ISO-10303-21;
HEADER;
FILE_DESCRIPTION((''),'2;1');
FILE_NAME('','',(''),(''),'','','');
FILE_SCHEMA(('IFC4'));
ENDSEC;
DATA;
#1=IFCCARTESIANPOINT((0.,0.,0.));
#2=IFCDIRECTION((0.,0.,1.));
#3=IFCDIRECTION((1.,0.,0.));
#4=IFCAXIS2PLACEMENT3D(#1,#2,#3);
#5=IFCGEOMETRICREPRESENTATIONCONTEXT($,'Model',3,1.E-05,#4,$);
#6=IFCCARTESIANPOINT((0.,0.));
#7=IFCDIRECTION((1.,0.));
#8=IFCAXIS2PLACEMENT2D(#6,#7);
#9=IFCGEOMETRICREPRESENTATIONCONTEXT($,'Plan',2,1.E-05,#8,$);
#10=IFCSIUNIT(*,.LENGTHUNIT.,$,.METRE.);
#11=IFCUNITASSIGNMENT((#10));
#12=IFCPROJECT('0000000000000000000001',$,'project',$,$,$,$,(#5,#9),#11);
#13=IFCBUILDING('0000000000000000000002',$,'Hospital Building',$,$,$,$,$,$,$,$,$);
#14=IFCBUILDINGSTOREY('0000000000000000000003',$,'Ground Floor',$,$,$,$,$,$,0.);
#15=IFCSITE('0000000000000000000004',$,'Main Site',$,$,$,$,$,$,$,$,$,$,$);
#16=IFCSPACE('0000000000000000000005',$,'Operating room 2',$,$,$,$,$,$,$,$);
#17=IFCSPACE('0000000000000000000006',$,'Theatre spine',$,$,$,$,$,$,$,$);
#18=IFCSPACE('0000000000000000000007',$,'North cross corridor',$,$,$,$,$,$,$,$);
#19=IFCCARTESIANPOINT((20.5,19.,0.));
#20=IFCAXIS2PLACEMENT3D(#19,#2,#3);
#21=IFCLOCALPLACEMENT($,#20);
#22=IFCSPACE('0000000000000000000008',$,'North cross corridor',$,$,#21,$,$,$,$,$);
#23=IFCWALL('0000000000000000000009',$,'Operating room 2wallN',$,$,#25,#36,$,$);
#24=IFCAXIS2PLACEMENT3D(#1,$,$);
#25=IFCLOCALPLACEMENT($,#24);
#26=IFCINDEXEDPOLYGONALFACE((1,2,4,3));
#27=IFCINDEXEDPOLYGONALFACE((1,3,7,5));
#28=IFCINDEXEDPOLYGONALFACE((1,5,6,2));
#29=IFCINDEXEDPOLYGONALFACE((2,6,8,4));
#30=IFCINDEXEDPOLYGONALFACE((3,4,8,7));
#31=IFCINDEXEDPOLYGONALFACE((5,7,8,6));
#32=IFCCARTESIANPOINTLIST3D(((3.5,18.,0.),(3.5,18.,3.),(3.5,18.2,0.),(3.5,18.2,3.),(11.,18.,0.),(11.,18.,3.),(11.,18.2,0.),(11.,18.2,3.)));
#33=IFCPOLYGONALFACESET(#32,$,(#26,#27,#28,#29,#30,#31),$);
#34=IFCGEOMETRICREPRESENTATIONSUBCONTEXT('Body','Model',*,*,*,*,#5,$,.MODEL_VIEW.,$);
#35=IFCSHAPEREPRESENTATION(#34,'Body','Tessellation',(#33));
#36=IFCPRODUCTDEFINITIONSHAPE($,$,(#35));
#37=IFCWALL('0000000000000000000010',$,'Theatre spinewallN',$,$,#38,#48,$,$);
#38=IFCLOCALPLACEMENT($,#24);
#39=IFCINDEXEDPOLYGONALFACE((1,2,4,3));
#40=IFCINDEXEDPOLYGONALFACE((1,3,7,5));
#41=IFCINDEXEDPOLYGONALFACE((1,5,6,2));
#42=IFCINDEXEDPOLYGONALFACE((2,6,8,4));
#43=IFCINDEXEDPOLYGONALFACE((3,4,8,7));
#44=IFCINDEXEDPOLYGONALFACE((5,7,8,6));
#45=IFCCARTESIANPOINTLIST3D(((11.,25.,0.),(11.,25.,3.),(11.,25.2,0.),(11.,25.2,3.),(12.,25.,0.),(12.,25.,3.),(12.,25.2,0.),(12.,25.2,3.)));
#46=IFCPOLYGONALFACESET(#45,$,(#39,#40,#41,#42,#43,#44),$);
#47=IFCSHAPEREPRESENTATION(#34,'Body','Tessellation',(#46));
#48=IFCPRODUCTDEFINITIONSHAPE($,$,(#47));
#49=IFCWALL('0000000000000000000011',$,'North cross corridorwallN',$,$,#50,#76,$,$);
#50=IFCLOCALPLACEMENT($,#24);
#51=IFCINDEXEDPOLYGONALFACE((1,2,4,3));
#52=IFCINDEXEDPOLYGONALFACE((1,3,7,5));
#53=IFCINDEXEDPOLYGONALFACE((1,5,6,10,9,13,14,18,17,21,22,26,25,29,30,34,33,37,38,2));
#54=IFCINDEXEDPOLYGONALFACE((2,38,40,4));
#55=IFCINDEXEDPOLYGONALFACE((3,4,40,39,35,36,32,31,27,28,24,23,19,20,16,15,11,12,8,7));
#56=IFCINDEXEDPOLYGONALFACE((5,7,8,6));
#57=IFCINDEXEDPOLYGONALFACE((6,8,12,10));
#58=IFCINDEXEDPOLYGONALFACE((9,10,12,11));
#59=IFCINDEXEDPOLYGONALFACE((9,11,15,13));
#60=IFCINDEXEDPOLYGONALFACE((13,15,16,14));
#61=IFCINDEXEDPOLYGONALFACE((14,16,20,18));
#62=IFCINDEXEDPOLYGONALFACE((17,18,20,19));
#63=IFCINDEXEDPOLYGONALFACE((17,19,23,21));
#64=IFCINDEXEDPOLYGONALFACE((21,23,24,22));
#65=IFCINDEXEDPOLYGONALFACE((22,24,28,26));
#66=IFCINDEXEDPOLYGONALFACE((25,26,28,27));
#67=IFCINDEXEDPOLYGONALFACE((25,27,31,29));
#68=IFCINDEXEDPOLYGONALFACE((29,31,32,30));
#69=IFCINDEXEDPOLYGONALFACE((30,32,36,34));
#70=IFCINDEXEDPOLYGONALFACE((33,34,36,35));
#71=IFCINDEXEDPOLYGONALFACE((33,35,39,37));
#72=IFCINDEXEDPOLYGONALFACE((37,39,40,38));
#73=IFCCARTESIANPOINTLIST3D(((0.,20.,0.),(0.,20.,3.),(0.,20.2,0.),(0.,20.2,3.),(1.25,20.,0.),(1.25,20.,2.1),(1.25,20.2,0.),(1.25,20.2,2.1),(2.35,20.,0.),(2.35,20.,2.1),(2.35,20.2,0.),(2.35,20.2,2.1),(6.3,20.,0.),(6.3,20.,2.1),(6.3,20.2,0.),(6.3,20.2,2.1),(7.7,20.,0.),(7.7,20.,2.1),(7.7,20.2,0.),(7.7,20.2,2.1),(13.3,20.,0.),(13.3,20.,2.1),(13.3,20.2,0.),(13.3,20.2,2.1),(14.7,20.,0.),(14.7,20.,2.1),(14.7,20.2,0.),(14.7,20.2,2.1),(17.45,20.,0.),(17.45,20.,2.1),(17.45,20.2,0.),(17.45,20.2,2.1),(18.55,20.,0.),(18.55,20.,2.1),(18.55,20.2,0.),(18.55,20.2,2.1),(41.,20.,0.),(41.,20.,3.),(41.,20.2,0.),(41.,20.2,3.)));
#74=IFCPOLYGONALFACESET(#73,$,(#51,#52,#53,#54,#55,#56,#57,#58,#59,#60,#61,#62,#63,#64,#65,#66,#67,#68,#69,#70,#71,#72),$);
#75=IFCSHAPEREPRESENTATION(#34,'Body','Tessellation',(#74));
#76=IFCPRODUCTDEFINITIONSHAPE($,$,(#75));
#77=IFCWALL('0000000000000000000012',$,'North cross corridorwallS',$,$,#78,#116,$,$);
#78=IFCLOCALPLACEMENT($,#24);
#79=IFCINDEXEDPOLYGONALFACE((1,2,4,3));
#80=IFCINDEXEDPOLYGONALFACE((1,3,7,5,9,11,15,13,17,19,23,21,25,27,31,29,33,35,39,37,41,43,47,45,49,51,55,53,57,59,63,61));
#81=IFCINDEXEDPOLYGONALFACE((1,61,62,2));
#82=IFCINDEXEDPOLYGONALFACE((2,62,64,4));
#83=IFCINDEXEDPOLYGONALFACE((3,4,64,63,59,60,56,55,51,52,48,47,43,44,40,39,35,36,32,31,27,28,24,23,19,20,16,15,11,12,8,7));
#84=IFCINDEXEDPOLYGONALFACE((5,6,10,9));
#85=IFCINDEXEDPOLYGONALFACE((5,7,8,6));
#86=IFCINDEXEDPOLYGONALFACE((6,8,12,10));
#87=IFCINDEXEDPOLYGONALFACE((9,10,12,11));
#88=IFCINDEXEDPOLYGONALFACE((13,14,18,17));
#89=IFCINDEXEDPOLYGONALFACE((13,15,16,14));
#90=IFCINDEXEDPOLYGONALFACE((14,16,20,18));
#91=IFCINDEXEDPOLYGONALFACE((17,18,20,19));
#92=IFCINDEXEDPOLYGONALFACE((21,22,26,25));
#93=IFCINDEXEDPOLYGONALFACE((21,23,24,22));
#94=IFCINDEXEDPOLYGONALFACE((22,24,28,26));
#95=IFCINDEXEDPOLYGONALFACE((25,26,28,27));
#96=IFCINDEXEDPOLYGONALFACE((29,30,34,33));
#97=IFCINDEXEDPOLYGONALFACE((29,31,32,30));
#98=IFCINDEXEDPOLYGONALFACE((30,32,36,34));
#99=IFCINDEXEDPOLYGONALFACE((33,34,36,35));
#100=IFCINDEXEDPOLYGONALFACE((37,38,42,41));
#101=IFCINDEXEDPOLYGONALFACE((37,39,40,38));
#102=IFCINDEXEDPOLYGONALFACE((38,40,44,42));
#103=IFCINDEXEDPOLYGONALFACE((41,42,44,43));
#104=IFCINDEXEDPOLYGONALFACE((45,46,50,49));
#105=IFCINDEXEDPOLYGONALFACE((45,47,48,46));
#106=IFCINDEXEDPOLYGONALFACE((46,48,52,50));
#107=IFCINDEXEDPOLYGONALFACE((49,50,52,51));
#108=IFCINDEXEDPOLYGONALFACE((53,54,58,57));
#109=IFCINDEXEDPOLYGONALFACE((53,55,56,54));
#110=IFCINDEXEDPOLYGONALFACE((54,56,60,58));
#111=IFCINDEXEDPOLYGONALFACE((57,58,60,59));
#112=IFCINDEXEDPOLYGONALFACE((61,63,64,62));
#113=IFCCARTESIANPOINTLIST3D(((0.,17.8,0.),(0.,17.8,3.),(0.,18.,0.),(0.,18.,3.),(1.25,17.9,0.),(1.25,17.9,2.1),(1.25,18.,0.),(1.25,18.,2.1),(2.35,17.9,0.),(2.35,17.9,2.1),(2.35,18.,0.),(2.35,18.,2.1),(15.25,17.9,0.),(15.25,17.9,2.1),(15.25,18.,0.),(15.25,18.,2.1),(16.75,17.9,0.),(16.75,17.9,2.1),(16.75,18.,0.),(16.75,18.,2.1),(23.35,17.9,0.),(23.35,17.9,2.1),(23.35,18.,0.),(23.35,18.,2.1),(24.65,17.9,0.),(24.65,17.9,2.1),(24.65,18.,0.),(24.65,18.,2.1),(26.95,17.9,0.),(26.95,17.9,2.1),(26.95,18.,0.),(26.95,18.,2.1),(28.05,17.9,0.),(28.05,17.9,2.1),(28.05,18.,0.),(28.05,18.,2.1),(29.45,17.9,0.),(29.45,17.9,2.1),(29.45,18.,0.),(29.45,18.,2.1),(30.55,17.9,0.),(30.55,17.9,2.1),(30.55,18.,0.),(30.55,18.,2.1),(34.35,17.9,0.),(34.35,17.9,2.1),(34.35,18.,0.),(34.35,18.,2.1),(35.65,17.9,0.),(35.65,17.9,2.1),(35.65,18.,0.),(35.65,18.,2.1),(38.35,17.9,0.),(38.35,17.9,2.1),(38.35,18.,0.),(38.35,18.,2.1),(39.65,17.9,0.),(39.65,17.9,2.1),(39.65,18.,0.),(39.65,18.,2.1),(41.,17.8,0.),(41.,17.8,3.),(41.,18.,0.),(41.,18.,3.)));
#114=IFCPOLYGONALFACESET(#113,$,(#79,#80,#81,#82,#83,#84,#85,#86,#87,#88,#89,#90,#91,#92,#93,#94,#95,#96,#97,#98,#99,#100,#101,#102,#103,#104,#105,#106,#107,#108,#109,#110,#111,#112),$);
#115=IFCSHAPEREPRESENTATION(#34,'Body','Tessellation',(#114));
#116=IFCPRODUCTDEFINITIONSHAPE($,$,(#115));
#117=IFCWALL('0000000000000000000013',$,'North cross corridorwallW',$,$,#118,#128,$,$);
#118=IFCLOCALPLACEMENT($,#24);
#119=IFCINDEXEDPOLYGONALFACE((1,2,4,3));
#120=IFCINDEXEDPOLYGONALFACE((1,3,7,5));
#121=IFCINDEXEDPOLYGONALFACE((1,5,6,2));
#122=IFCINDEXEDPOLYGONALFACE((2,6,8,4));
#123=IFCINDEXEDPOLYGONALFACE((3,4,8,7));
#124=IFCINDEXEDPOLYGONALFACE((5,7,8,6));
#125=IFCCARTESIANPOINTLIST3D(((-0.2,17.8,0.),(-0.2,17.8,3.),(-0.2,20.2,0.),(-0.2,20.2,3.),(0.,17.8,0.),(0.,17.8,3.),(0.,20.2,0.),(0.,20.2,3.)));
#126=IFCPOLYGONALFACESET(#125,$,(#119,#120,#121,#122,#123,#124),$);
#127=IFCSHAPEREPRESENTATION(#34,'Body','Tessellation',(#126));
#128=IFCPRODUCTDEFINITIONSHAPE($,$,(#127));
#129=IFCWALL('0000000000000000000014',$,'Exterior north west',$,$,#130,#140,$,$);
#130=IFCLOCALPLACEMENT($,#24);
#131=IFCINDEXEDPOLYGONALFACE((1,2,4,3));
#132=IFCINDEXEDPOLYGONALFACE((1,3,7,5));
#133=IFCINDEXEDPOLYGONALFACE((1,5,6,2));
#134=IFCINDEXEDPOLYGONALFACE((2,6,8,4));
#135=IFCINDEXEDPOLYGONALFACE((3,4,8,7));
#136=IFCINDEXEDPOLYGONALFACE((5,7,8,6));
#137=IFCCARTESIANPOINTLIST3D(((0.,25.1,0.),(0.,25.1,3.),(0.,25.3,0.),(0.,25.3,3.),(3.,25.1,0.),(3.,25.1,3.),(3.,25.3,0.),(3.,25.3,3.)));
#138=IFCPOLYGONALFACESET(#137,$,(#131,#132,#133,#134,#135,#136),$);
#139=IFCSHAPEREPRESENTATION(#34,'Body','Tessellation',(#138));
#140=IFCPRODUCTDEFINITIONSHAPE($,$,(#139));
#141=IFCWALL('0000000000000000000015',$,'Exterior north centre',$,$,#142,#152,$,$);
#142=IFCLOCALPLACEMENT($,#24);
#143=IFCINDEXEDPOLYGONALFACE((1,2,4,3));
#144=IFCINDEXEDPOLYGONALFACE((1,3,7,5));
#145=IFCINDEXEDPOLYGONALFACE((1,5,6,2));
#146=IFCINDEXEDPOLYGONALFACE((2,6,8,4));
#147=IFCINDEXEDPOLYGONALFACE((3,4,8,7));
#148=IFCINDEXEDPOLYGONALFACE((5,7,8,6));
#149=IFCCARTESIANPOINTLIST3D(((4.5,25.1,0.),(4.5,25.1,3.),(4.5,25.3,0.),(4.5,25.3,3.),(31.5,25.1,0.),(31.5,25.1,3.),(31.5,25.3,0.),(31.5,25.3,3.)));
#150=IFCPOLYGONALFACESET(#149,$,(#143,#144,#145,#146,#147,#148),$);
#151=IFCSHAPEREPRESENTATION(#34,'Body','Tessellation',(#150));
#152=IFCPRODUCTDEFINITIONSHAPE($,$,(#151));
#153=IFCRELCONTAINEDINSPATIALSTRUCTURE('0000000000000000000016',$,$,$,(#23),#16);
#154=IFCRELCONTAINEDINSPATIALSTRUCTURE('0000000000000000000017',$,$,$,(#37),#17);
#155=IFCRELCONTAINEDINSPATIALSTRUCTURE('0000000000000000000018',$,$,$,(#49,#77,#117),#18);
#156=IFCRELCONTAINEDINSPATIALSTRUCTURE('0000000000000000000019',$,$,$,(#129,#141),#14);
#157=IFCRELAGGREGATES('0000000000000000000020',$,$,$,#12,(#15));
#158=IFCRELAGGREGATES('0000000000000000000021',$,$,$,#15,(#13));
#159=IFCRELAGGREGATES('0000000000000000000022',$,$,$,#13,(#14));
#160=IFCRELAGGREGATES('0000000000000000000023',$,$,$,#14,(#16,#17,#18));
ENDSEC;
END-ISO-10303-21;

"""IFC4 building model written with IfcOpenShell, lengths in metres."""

from ifc_helpers import new_model, si_unit, frame, origin_with_axes, origin_2d_with_axis, place, context, subcontext, project, spatial, indexed_curve, outline, extrude, element, save


model = new_model("IFC4")

# Units and contexts
model_context = context("Model", 3, precision=1e-05, world=origin_with_axes())
plan_context = context("Plan", 2, precision=1e-05, world=origin_2d_with_axis())
body_context = subcontext(model_context, "Body", "Model", "MODEL_VIEW")
ifc_project = project(units=[si_unit("LENGTHUNIT", "METRE")], contexts=[model_context, plan_context])

# Site, building, storey
site = spatial("IfcSite", under=ifc_project, Name="Main Site")
building = spatial("IfcBuilding", under=site, Name="Hospital Building")
storey = spatial("IfcBuildingStorey", under=building, Name="Ground Floor", Elevation=0.0)

# Shared definitions
space_1 = spatial("IfcSpace", under=storey, Name="Operating room 2")

# Shared definitions
space_2 = spatial("IfcSpace", under=storey, Name="Theatre spine")

# Walls
wall_1_placement = place(None, frame((3.5, 18.0, 0.0), z_axis=(0.0, 0.0, 1.0), x_axis=(1.0, 0.0, 0.0)))
element("IfcWall", 1, at=wall_1_placement, inside=space_1, Name="Operating room 2wallN", context=body_context, shape_type="SweptSolid", body=[
    extrude(outline(indexed_curve([(0.0, 0.0), (0.0, 0.2), (7.5, 0.2), (7.5, 0.0), (0.0, 0.0)], self_intersect=False)), origin_with_axes(), (0.0, 0.0, 1.0), 3.0),
])
wall_2_placement = place(None, frame((11.0, 25.0, 0.0), z_axis=(0.0, 0.0, 1.0), x_axis=(1.0, 0.0, 0.0)))
element("IfcWall", 2, at=wall_2_placement, inside=space_2, Name="Theatre spinewallN", context=body_context, shape_type="SweptSolid", body=[
    extrude(outline(indexed_curve([(0.0, 0.0), (0.0, 0.2), (1.0, 0.2), (1.0, 0.0), (0.0, 0.0)], self_intersect=False)), origin_with_axes(), (0.0, 0.0, 1.0), 3.0),
])

# Shared definitions
space_3 = spatial("IfcSpace", under=storey, Name="North cross corridor")

# Wall
wall_3_placement = place(None, frame((0.0, 20.0, 0.0), z_axis=(0.0, 0.0, 1.0), x_axis=(1.0, 0.0, 0.0)))
wall_3 = element("IfcWall", 3, at=wall_3_placement, inside=space_3, Name="North cross corridorwallN", context=body_context, shape_type="SweptSolid", body=[
    extrude(outline(indexed_curve([(0.0, 0.0), (0.0, 0.2), (41.0, 0.2), (41.0, 0.0), (0.0, 0.0)], self_intersect=False)), origin_with_axes(), (0.0, 0.0, 1.0), 3.0),
])

# Shared definitions
space_4_placement = place(None, frame((20.5, 19.0, 0.0), z_axis=(0.0, 0.0, 1.0), x_axis=(1.0, 0.0, 0.0)))
space_4 = spatial("IfcSpace", at=space_4_placement, Name="North cross corridor")

# Openings
opening_1_placement = place(wall_3_placement, frame((1.25, -0.1, 0.0), z_axis=(0.0, 0.0, 1.0), x_axis=(1.0, 0.0, 0.0)))
element("IfcOpeningElement", 4, at=opening_1_placement, inside=space_4, cuts=wall_3, context=body_context, shape_type="SweptSolid", body=[
    extrude(outline(indexed_curve([(0.0, 0.0), (0.0, 0.4), (1.1, 0.4), (1.1, 0.0), (0.0, 0.0)], self_intersect=False)), origin_with_axes(), (0.0, 0.0, 1.0), 2.1),
])
opening_2_placement = place(wall_3_placement, frame((6.3, -0.1, 0.0), z_axis=(0.0, 0.0, 1.0), x_axis=(1.0, 0.0, 0.0)))
element("IfcOpeningElement", 5, at=opening_2_placement, inside=space_4, cuts=wall_3, context=body_context, shape_type="SweptSolid", body=[
    extrude(outline(indexed_curve([(0.0, 0.0), (0.0, 0.4), (1.4, 0.4), (1.4, 0.0), (0.0, 0.0)], self_intersect=False)), origin_with_axes(), (0.0, 0.0, 1.0), 2.1),
])
opening_3_placement = place(wall_3_placement, frame((13.3, -0.1, 0.0), z_axis=(0.0, 0.0, 1.0), x_axis=(1.0, 0.0, 0.0)))
element("IfcOpeningElement", 6, at=opening_3_placement, inside=space_4, cuts=wall_3, context=body_context, shape_type="SweptSolid", body=[
    extrude(outline(indexed_curve([(0.0, 0.0), (0.0, 0.4), (1.4, 0.4), (1.4, 0.0), (0.0, 0.0)], self_intersect=False)), origin_with_axes(), (0.0, 0.0, 1.0), 2.1),
])
opening_4_placement = place(wall_3_placement, frame((17.45, -0.1, 0.0), z_axis=(0.0, 0.0, 1.0), x_axis=(1.0, 0.0, 0.0)))
element("IfcOpeningElement", 7, at=opening_4_placement, inside=space_4, cuts=wall_3, context=body_context, shape_type="SweptSolid", body=[
    extrude(outline(indexed_curve([(0.0, 0.0), (0.0, 0.4), (1.1, 0.4), (1.1, 0.0), (0.0, 0.0)], self_intersect=False)), origin_with_axes(), (0.0, 0.0, 1.0), 2.1),
])

# Wall, openings
wall_4_placement = place(None, frame((0.0, 17.8, 0.0), z_axis=(0.0, 0.0, 1.0), x_axis=(1.0, 0.0, 0.0)))
wall_4 = element("IfcWall", 8, at=wall_4_placement, inside=space_3, Name="North cross corridorwallS", context=body_context, shape_type="SweptSolid", body=[
    extrude(outline(indexed_curve([(0.0, 0.0), (0.0, 0.2), (41.0, 0.2), (41.0, 0.0), (0.0, 0.0)], self_intersect=False)), origin_with_axes(), (0.0, 0.0, 1.0), 3.0),
])
opening_5_placement = place(wall_4_placement, frame((1.25, 0.1, 0.0), z_axis=(0.0, 0.0, 1.0), x_axis=(1.0, 0.0, 0.0)))
element("IfcOpeningElement", 9, at=opening_5_placement, inside=space_4, cuts=wall_4, context=body_context, shape_type="SweptSolid", body=[
    extrude(outline(indexed_curve([(0.0, 0.0), (0.0, 0.4), (1.1, 0.4), (1.1, 0.0), (0.0, 0.0)], self_intersect=False)), origin_with_axes(), (0.0, 0.0, 1.0), 2.1),
])
opening_6_placement = place(wall_4_placement, frame((15.25, 0.1, 0.0), z_axis=(0.0, 0.0, 1.0), x_axis=(1.0, 0.0, 0.0)))
element("IfcOpeningElement", 10, at=opening_6_placement, inside=space_4, cuts=wall_4, context=body_context, shape_type="SweptSolid", body=[
    extrude(outline(indexed_curve([(0.0, 0.0), (0.0, 0.4), (1.5, 0.4), (1.5, 0.0), (0.0, 0.0)], self_intersect=False)), origin_with_axes(), (0.0, 0.0, 1.0), 2.1),
])
opening_7_placement = place(wall_4_placement, frame((23.35, 0.1, 0.0), z_axis=(0.0, 0.0, 1.0), x_axis=(1.0, 0.0, 0.0)))
element("IfcOpeningElement", 11, at=opening_7_placement, inside=space_4, cuts=wall_4, context=body_context, shape_type="SweptSolid", body=[
    extrude(outline(indexed_curve([(0.0, 0.0), (0.0, 0.4), (1.3, 0.4), (1.3, 0.0), (0.0, 0.0)], self_intersect=False)), origin_with_axes(), (0.0, 0.0, 1.0), 2.1),
])
opening_8_placement = place(wall_4_placement, frame((26.95, 0.1, 0.0), z_axis=(0.0, 0.0, 1.0), x_axis=(1.0, 0.0, 0.0)))
element("IfcOpeningElement", 12, at=opening_8_placement, inside=space_4, cuts=wall_4, context=body_context, shape_type="SweptSolid", body=[
    extrude(outline(indexed_curve([(0.0, 0.0), (0.0, 0.4), (1.1, 0.4), (1.1, 0.0), (0.0, 0.0)], self_intersect=False)), origin_with_axes(), (0.0, 0.0, 1.0), 2.1),
])
opening_9_placement = place(wall_4_placement, frame((29.45, 0.1, 0.0), z_axis=(0.0, 0.0, 1.0), x_axis=(1.0, 0.0, 0.0)))
element("IfcOpeningElement", 13, at=opening_9_placement, inside=space_4, cuts=wall_4, context=body_context, shape_type="SweptSolid", body=[
    extrude(outline(indexed_curve([(0.0, 0.0), (0.0, 0.4), (1.1, 0.4), (1.1, 0.0), (0.0, 0.0)], self_intersect=False)), origin_with_axes(), (0.0, 0.0, 1.0), 2.1),
])
opening_10_placement = place(wall_4_placement, frame((34.35, 0.1, 0.0), z_axis=(0.0, 0.0, 1.0), x_axis=(1.0, 0.0, 0.0)))
element("IfcOpeningElement", 14, at=opening_10_placement, inside=space_4, cuts=wall_4, context=body_context, shape_type="SweptSolid", body=[
    extrude(outline(indexed_curve([(0.0, 0.0), (0.0, 0.4), (1.3, 0.4), (1.3, 0.0), (0.0, 0.0)], self_intersect=False)), origin_with_axes(), (0.0, 0.0, 1.0), 2.1),
])
opening_11_placement = place(wall_4_placement, frame((38.35, 0.1, 0.0), z_axis=(0.0, 0.0, 1.0), x_axis=(1.0, 0.0, 0.0)))
element("IfcOpeningElement", 15, at=opening_11_placement, inside=space_4, cuts=wall_4, context=body_context, shape_type="SweptSolid", body=[
    extrude(outline(indexed_curve([(0.0, 0.0), (0.0, 0.4), (1.3, 0.4), (1.3, 0.0), (0.0, 0.0)], self_intersect=False)), origin_with_axes(), (0.0, 0.0, 1.0), 2.1),
])

# Walls
wall_5_placement = place(None, frame((0.0, 17.8, 0.0), z_axis=(0.0, 0.0, 1.0), x_axis=(0.0, 1.0, 0.0)))
element("IfcWall", 16, at=wall_5_placement, inside=space_3, Name="North cross corridorwallW", context=body_context, shape_type="SweptSolid", body=[
    extrude(outline(indexed_curve([(0.0, 0.0), (0.0, 0.2), (2.4, 0.2), (2.4, 0.0), (0.0, 0.0)], self_intersect=False)), origin_with_axes(), (0.0, 0.0, 1.0), 3.0),
])
wall_6_placement = place(None, frame((0.0, 25.1, 0.0), z_axis=(0.0, 0.0, 1.0), x_axis=(1.0, 0.0, 0.0)))
element("IfcWall", 17, at=wall_6_placement, inside=storey, Name="Exterior north west", context=body_context, shape_type="SweptSolid", body=[
    extrude(outline(indexed_curve([(0.0, 0.0), (0.0, 0.2), (3.0, 0.2), (3.0, 0.0), (0.0, 0.0)], self_intersect=False)), origin_with_axes(), (0.0, 0.0, 1.0), 3.0),
])
wall_7_placement = place(None, frame((4.5, 25.1, 0.0), z_axis=(0.0, 0.0, 1.0), x_axis=(1.0, 0.0, 0.0)))
element("IfcWall", 18, at=wall_7_placement, inside=storey, Name="Exterior north centre", context=body_context, shape_type="SweptSolid", body=[
    extrude(outline(indexed_curve([(0.0, 0.0), (0.0, 0.2), (27.0, 0.2), (27.0, 0.0), (0.0, 0.0)], self_intersect=False)), origin_with_axes(), (0.0, 0.0, 1.0), 3.0),
])

save(model, "model.ifc")
